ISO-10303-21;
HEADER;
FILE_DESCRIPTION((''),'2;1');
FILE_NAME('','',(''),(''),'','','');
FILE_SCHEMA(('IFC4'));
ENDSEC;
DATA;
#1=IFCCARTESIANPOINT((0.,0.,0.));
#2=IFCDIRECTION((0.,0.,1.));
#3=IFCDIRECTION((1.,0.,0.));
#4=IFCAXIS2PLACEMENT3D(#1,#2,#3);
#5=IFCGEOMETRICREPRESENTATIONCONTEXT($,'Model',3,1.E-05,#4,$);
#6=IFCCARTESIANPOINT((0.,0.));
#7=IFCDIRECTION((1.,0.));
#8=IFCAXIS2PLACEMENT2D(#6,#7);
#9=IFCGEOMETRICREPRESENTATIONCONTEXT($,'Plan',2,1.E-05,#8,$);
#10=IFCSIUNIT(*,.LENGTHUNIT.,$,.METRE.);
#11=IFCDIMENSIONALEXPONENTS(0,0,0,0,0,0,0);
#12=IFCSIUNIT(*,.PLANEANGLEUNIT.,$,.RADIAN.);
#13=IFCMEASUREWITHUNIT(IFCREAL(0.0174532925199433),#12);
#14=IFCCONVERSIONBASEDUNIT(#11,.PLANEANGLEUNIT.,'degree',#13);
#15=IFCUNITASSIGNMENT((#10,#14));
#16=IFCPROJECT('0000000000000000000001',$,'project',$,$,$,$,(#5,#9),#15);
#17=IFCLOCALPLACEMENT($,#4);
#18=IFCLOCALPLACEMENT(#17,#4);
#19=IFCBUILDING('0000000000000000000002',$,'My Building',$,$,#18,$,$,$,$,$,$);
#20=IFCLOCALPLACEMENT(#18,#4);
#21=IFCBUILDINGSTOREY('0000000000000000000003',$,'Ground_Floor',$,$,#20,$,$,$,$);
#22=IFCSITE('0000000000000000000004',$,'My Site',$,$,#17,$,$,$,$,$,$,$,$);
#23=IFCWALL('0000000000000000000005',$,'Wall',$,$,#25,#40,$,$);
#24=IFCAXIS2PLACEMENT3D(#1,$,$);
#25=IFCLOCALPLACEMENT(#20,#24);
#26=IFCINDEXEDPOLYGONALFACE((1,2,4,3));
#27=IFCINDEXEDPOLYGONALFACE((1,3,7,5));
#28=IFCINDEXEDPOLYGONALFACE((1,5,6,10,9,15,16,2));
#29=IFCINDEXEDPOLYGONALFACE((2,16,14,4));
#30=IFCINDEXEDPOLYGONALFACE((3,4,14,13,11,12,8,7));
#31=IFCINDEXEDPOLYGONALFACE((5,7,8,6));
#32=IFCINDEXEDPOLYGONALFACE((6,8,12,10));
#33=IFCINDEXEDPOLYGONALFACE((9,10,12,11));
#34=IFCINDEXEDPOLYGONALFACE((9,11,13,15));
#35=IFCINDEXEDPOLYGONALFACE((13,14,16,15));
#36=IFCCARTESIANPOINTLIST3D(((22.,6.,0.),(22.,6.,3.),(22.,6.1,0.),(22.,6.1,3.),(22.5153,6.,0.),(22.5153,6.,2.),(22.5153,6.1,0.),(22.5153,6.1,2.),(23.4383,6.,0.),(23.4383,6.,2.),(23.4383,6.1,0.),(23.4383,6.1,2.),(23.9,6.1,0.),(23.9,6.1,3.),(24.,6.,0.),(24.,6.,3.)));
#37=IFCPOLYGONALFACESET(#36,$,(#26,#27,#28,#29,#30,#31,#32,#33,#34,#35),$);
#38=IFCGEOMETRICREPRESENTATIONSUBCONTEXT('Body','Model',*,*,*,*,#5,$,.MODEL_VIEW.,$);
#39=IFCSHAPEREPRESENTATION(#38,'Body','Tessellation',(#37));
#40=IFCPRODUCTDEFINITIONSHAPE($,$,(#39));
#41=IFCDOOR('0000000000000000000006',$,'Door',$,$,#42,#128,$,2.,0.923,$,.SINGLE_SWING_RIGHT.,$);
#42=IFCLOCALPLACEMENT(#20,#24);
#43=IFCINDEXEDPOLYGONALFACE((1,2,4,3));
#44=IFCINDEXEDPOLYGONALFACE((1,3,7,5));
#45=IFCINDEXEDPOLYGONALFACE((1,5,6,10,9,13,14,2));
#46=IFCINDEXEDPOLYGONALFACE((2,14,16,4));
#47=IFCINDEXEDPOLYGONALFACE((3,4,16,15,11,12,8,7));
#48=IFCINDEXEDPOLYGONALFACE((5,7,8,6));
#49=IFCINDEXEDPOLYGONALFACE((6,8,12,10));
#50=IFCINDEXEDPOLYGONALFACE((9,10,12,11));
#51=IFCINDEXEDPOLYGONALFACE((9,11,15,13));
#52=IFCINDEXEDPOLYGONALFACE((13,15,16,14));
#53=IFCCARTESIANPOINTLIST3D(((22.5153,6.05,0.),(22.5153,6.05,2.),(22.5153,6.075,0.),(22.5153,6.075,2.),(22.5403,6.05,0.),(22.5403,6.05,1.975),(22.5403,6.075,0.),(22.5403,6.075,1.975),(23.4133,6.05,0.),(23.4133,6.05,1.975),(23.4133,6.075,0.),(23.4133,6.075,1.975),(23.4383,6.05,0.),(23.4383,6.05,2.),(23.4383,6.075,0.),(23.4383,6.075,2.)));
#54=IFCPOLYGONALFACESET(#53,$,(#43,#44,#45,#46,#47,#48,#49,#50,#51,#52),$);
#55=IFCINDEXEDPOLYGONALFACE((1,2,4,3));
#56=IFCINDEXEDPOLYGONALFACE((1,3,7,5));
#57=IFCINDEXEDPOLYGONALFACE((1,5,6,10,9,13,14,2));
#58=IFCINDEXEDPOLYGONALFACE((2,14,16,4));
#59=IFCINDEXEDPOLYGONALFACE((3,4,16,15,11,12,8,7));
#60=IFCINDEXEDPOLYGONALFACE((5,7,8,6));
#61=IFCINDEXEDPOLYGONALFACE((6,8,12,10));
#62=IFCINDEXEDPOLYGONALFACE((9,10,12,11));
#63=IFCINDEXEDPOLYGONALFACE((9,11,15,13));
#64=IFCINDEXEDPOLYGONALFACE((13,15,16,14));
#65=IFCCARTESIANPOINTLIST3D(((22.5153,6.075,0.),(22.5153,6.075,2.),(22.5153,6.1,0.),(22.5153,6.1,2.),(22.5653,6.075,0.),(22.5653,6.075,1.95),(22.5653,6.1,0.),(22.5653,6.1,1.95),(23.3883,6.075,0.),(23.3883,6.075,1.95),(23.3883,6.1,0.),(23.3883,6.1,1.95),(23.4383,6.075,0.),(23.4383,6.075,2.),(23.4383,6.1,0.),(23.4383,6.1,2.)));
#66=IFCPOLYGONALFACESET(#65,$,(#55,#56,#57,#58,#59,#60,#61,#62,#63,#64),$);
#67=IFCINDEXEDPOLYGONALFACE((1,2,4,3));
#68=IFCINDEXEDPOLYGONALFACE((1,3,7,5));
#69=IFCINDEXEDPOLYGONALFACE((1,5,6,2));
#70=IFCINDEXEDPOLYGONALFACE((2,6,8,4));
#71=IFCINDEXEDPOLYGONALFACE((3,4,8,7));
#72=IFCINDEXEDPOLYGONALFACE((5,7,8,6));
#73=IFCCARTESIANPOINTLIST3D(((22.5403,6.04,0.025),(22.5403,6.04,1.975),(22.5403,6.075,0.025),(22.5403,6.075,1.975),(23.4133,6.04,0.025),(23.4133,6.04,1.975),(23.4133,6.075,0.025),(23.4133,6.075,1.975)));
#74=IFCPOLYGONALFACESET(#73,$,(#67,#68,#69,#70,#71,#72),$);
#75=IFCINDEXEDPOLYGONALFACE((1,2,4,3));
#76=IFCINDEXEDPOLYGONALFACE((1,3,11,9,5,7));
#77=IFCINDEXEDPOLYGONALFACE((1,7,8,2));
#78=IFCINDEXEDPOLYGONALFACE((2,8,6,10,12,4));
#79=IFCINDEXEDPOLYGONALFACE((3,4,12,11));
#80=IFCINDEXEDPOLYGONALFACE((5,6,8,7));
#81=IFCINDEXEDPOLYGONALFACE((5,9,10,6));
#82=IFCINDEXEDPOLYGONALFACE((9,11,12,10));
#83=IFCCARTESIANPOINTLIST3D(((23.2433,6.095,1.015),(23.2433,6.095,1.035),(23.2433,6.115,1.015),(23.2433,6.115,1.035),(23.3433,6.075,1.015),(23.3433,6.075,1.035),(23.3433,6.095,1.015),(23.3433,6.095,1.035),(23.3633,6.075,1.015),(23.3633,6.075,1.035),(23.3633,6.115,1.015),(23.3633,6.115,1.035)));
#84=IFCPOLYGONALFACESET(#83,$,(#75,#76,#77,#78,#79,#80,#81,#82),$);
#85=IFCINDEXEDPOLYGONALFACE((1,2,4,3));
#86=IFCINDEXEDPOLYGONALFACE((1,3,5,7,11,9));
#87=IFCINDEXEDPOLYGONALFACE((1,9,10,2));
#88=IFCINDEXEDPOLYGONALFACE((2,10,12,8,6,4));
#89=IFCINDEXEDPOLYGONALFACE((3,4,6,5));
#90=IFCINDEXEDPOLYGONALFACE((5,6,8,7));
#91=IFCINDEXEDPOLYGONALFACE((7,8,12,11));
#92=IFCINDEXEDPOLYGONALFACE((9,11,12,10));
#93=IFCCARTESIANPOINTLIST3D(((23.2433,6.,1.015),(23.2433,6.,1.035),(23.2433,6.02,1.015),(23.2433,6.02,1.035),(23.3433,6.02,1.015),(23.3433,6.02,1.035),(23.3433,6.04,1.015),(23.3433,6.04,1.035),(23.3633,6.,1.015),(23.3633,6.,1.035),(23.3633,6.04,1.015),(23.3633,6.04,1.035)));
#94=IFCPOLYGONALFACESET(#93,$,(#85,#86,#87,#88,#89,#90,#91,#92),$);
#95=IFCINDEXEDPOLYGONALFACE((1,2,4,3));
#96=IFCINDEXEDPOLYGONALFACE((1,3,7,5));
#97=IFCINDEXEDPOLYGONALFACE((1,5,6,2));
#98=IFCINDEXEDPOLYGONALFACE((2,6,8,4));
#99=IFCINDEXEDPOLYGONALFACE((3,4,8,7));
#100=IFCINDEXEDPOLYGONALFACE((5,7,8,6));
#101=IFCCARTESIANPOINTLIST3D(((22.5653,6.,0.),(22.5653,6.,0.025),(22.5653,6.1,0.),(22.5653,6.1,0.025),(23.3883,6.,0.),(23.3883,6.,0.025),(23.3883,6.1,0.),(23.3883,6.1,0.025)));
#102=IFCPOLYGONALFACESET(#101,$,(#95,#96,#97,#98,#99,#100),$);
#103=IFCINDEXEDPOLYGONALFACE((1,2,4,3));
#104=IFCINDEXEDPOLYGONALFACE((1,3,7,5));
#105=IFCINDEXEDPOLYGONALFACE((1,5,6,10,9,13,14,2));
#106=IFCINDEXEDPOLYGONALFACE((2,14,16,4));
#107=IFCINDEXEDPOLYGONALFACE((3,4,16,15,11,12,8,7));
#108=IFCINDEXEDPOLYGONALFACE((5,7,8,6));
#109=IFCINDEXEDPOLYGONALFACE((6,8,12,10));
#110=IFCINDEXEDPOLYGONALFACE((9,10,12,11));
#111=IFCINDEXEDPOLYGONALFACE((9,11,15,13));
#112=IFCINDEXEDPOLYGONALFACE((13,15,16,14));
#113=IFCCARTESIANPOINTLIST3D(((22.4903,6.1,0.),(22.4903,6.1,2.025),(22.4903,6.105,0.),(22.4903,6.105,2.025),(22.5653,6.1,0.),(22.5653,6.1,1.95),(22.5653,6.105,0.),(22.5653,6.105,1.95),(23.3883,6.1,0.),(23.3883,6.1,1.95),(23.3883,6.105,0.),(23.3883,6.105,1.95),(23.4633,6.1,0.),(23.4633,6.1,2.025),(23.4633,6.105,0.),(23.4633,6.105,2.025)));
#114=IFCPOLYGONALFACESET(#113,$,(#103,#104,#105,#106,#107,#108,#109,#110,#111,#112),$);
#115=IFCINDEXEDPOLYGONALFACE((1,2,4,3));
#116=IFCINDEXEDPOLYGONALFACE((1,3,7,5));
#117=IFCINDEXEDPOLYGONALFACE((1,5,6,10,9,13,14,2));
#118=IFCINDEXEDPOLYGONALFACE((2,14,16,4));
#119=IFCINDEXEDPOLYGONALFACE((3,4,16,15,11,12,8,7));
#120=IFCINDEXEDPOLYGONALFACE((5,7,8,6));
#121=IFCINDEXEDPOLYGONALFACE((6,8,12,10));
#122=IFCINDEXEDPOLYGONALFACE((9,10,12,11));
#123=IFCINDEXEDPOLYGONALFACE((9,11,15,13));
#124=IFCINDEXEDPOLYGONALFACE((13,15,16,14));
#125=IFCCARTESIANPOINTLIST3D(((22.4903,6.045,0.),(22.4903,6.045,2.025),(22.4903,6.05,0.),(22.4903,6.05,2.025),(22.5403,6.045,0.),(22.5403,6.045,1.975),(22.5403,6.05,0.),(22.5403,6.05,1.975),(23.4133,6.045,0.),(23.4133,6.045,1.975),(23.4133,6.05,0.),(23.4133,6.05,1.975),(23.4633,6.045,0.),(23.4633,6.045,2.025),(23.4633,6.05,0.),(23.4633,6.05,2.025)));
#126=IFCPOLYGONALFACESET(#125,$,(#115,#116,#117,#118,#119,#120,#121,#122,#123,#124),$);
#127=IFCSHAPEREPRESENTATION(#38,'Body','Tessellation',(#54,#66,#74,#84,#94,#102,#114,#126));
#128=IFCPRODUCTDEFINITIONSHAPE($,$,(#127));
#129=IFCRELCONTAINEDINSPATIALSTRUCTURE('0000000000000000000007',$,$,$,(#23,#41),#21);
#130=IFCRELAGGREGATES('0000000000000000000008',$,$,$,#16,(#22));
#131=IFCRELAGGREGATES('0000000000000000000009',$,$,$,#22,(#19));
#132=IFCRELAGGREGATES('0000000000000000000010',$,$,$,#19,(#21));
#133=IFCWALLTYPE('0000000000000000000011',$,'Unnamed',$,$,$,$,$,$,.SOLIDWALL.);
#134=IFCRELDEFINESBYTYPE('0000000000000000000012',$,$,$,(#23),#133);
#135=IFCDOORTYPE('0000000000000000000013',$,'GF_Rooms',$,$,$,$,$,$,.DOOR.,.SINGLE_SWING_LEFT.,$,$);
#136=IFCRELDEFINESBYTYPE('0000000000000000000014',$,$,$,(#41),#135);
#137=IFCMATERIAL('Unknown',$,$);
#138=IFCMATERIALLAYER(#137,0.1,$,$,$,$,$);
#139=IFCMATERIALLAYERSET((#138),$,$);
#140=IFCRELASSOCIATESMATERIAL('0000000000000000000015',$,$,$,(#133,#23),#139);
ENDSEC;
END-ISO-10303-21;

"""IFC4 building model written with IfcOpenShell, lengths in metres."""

from ifc_helpers import new_model, entity, si_unit, converted_unit, frame, origin_with_axes, origin_2d_with_axis, place, context, subcontext, project, spatial, line, indexed_curve, outline, extrude, shape, source, transform, mapped, material, layer, layer_set, layer_usage, type_object, type_shapes, element, fill, save


model = new_model("IFC4")

# Units and contexts
model_context = context("Model", 3, precision=1e-05, world=origin_with_axes())
plan_context = context("Plan", 2, precision=1e-05, world=origin_2d_with_axis())
body_context_1 = subcontext(model_context, "Body", "Model", "MODEL_VIEW")
body_context_2 = subcontext(plan_context, "Body", "Plan", "PLAN_VIEW")
ifc_project = project(units=[si_unit("LENGTHUNIT", "METRE"), converted_unit("PLANEANGLEUNIT", "degree", entity("IfcReal", 0.0174532925199433), si_unit("PLANEANGLEUNIT", "RADIAN"), dimensions=[0, 0, 0, 0, 0, 0, 0])], contexts=[model_context, plan_context])

# Site, building, storey
site_placement = place(None, origin_with_axes())
site = spatial("IfcSite", under=ifc_project, at=site_placement, Name="My Site")
building_placement = place(site_placement, origin_with_axes())
building = spatial("IfcBuilding", under=site, at=building_placement, Name="My Building")
storey_placement = place(building_placement, origin_with_axes())
storey = spatial("IfcBuildingStorey", under=building, at=storey_placement, Name="Ground_Floor")

# Shared definitions
ifc_material = material(Name="Unknown")
ifc_layer = layer(ifc_material, 0.1)
ifc_layer_set = layer_set([ifc_layer])
wall_type = type_object("IfcWallType", Name="Unnamed", PredefinedType="SOLIDWALL", material=ifc_layer_set)

# Shared definitions
shared_shape_1 = source(origin_with_axes(), body_context_1, "Body", "SweptSolid", [
    extrude(outline(indexed_curve([(0.0, 0.0), (0.923, 0.0), (0.923, 2.0), (0.0, 2.0)], segments=[line(1, 2, 3, 4, 1)])), frame((0.0, -0.6, 0.0), z_axis=(0.0, -1.0, 0.0), x_axis=(1.0, 0.0, 0.0)), (0.0, 0.0, -1.0), 1.2),
])
door_type_1 = type_object("IfcDoorType", Name="GF_Rooms", OperationType="SINGLE_SWING_LEFT", PredefinedType="DOOR")
shared_shape_2 = source(origin_with_axes(), body_context_1, "Body", "SweptSolid", [
    extrude(outline(indexed_curve([(0.0, 0.0), (0.0, 2.0), (0.923, 2.0), (0.923, 0.0), (0.898, 0.0), (0.898, 1.975), (0.025, 1.975), (0.025, 0.0)], segments=[line(1, 2, 3, 4, 5, 6, 7, 8, 1)])), frame((0.0, 0.025, 0.0), z_axis=(0.0, -1.0, 0.0), x_axis=(1.0, 0.0, 0.0)), (0.0, 0.0, -1.0), 0.025),
    extrude(outline(indexed_curve([(0.0, 0.0), (0.0, 2.0), (0.923, 2.0), (0.923, 0.0), (0.873, 0.0), (0.873, 1.95), (0.05, 1.95), (0.05, 0.0)], segments=[line(1, 2, 3, 4, 5, 6, 7, 8, 1)])), frame((0.0, 0.0, 0.0), z_axis=(0.0, -1.0, 0.0), x_axis=(1.0, 0.0, 0.0)), (0.0, 0.0, -1.0), 0.025),
    extrude(outline(indexed_curve([(0.0, 0.0), (0.873, 0.0), (0.873, 0.035), (0.0, 0.035)], segments=[line(1, 2, 3, 4, 1)])), frame((0.025, 0.025, 0.025), z_axis=(0.0, 0.0, 1.0), x_axis=(1.0, 0.0, 0.0)), (0.0, 0.0, 1.0), 1.95),
    extrude(outline(indexed_curve([(0.0, 0.0), (0.0, -0.04), (0.12, -0.04), (0.12, -0.02), (0.02, -0.02), (0.02, 0.0)], segments=[line(1, 2, 3, 4, 5, 6, 1)])), frame((0.075, 0.025, 1.015), z_axis=(0.0, 0.0, 1.0), x_axis=(1.0, 0.0, 0.0)), (0.0, 0.0, 1.0), 0.02),
    extrude(outline(indexed_curve([(0.0, 0.0), (0.0, 0.04), (0.12, 0.04), (0.12, 0.02), (0.02, 0.02), (0.02, 0.0)], segments=[line(1, 2, 3, 4, 5, 6, 1)])), frame((0.075, 0.06, 1.015), z_axis=(0.0, 0.0, 1.0), x_axis=(1.0, 0.0, 0.0)), (0.0, 0.0, 1.0), 0.02),
    extrude(outline(indexed_curve([(0.0, 0.0), (0.823, 0.0), (0.823, 0.1), (0.0, 0.1)], segments=[line(1, 2, 3, 4, 1)])), frame((0.05, 0.0, 0.0), z_axis=(0.0, 0.0, 1.0), x_axis=(1.0, 0.0, 0.0)), (0.0, 0.0, 1.0), 0.025),
    extrude(outline(indexed_curve([(0.0, 0.0), (0.0, 2.025), (0.973, 2.025), (0.973, 0.0), (0.898, 0.0), (0.898, 1.95), (0.075, 1.95), (0.075, 0.0)], segments=[line(1, 2, 3, 4, 5, 6, 7, 8, 1)])), frame((-0.025, -0.005, 0.0), z_axis=(0.0, -1.0, 0.0), x_axis=(1.0, 0.0, 0.0)), (0.0, 0.0, -1.0), 0.005),
    extrude(outline(indexed_curve([(0.0, 0.0), (0.0, 2.025), (0.973, 2.025), (0.973, 0.0), (0.923, 0.0), (0.923, 1.975), (0.05, 1.975), (0.05, 0.0)], segments=[line(1, 2, 3, 4, 5, 6, 7, 8, 1)])), frame((-0.025, 0.05, 0.0), z_axis=(0.0, -1.0, 0.0), x_axis=(1.0, 0.0, 0.0)), (0.0, 0.0, -1.0), 0.005),
])
shared_shape_3 = source(origin_with_axes(), body_context_2, "Body", "Curve2D", [
    entity("IfcIndexedPolyCurve", entity("IfcCartesianPointList2D", [[0.0, 0.0], [0.0, 0.05], [0.025, 0.05], [0.025, 0.025], [0.05, 0.025], [0.05, 0.0]]), [entity("IfcLineIndex", [1, 2, 3, 4, 5, 6, 1])]),
    entity("IfcIndexedPolyCurve", entity("IfcCartesianPointList2D", [[0.923, 0.0], [0.923, 0.05], [0.898, 0.05], [0.898, 0.025], [0.873, 0.025], [0.873, 0.0]]), [entity("IfcLineIndex", [1, 2, 3, 4, 5, 6, 1])]),
    entity("IfcTrimmedCurve", entity("IfcEllipse", entity("IfcAxis2Placement2D", entity("IfcCartesianPoint", [0.863, 0.05]), entity("IfcDirection", [1.0, 0.0])), 0.838, 0.873), [entity("IfcCartesianPoint", [0.863, 0.923])], [entity("IfcCartesianPoint", [0.025, 0.05])], True, "CARTESIAN"),
    entity("IfcIndexedPolyCurve", entity("IfcCartesianPointList2D", [[0.898, 0.05], [0.863, 0.05], [0.863, 0.923], [0.898, 0.923]]), [entity("IfcLineIndex", [1, 2, 3, 4, 1])]),
])
type_shapes(door_type_1, [shared_shape_2, shared_shape_3])

# Wall, opening, door
ifc_layer_usage_1 = layer_usage(ifc_layer_set, "AXIS2", "POSITIVE", 0.0)
wall_1_placement = place(storey_placement, frame((22.0, 6.0, 0.0), z_axis=(0.0, 0.0, 1.0), x_axis=(1.0, 0.0, 0.0)))
wall_1 = element("IfcWall", 1, at=wall_1_placement, inside=storey, type_object=wall_type, material=ifc_layer_usage_1, Name="Wall", context=body_context_1, shape_type="SweptSolid", body=[
    extrude(outline(indexed_curve([(0.0, 0.0), (0.0, 0.1), (1.9, 0.1), (2.0, 0.0)], segments=[line(1, 2, 3, 4, 1)])), origin_with_axes(), (0.0, 0.0, 1.0), 3.0),
])
opening_1_placement = place(wall_1_placement, frame((1.4383, 0.1, 0.0), z_axis=(0.0, 0.0, 1.0), x_axis=(-1.0, 0.0, 0.0)))
opening_1 = element("IfcOpeningElement", 2, at=opening_1_placement, cuts=wall_1, PredefinedType="OPENING", context=body_context_1, shape_type="MappedRepresentation", body=[
    mapped(shared_shape_1, transform((0.0, 0.0, 0.0), x_axis=(1.0, 0.0, 0.0), y_axis=(0.0, 1.0, 0.0), z_axis=(0.0, 0.0, 1.0), scale=1.0)),
])
door_1_placement = place(opening_1_placement, frame((0.0, 0.0, 0.0), z_axis=(0.0, 0.0, 1.0), x_axis=(1.0, 0.0, 0.0)))
door_1 = element("IfcDoor", 3, at=door_1_placement, inside=storey, type_object=door_type_1, Name="Door", OperationType="SINGLE_SWING_RIGHT", OverallHeight=2.0, OverallWidth=0.923, shapes=[
    shape(body_context_1, "Body", "MappedRepresentation", [mapped(shared_shape_2, transform((0.0, 0.0, 0.0), x_axis=(1.0, 0.0, 0.0), y_axis=(0.0, 1.0, 0.0), z_axis=(0.0, 0.0, 1.0), scale=1.0))]),
    shape(body_context_2, "Body", "MappedRepresentation", [mapped(shared_shape_3, transform((0.0, 0.0, 0.0), x_axis=(1.0, 0.0, 0.0), y_axis=(0.0, 1.0, 0.0), z_axis=(0.0, 0.0, 1.0), scale=1.0))]),
])
fill(opening_1, door_1)

save(model, "model.ifc")
